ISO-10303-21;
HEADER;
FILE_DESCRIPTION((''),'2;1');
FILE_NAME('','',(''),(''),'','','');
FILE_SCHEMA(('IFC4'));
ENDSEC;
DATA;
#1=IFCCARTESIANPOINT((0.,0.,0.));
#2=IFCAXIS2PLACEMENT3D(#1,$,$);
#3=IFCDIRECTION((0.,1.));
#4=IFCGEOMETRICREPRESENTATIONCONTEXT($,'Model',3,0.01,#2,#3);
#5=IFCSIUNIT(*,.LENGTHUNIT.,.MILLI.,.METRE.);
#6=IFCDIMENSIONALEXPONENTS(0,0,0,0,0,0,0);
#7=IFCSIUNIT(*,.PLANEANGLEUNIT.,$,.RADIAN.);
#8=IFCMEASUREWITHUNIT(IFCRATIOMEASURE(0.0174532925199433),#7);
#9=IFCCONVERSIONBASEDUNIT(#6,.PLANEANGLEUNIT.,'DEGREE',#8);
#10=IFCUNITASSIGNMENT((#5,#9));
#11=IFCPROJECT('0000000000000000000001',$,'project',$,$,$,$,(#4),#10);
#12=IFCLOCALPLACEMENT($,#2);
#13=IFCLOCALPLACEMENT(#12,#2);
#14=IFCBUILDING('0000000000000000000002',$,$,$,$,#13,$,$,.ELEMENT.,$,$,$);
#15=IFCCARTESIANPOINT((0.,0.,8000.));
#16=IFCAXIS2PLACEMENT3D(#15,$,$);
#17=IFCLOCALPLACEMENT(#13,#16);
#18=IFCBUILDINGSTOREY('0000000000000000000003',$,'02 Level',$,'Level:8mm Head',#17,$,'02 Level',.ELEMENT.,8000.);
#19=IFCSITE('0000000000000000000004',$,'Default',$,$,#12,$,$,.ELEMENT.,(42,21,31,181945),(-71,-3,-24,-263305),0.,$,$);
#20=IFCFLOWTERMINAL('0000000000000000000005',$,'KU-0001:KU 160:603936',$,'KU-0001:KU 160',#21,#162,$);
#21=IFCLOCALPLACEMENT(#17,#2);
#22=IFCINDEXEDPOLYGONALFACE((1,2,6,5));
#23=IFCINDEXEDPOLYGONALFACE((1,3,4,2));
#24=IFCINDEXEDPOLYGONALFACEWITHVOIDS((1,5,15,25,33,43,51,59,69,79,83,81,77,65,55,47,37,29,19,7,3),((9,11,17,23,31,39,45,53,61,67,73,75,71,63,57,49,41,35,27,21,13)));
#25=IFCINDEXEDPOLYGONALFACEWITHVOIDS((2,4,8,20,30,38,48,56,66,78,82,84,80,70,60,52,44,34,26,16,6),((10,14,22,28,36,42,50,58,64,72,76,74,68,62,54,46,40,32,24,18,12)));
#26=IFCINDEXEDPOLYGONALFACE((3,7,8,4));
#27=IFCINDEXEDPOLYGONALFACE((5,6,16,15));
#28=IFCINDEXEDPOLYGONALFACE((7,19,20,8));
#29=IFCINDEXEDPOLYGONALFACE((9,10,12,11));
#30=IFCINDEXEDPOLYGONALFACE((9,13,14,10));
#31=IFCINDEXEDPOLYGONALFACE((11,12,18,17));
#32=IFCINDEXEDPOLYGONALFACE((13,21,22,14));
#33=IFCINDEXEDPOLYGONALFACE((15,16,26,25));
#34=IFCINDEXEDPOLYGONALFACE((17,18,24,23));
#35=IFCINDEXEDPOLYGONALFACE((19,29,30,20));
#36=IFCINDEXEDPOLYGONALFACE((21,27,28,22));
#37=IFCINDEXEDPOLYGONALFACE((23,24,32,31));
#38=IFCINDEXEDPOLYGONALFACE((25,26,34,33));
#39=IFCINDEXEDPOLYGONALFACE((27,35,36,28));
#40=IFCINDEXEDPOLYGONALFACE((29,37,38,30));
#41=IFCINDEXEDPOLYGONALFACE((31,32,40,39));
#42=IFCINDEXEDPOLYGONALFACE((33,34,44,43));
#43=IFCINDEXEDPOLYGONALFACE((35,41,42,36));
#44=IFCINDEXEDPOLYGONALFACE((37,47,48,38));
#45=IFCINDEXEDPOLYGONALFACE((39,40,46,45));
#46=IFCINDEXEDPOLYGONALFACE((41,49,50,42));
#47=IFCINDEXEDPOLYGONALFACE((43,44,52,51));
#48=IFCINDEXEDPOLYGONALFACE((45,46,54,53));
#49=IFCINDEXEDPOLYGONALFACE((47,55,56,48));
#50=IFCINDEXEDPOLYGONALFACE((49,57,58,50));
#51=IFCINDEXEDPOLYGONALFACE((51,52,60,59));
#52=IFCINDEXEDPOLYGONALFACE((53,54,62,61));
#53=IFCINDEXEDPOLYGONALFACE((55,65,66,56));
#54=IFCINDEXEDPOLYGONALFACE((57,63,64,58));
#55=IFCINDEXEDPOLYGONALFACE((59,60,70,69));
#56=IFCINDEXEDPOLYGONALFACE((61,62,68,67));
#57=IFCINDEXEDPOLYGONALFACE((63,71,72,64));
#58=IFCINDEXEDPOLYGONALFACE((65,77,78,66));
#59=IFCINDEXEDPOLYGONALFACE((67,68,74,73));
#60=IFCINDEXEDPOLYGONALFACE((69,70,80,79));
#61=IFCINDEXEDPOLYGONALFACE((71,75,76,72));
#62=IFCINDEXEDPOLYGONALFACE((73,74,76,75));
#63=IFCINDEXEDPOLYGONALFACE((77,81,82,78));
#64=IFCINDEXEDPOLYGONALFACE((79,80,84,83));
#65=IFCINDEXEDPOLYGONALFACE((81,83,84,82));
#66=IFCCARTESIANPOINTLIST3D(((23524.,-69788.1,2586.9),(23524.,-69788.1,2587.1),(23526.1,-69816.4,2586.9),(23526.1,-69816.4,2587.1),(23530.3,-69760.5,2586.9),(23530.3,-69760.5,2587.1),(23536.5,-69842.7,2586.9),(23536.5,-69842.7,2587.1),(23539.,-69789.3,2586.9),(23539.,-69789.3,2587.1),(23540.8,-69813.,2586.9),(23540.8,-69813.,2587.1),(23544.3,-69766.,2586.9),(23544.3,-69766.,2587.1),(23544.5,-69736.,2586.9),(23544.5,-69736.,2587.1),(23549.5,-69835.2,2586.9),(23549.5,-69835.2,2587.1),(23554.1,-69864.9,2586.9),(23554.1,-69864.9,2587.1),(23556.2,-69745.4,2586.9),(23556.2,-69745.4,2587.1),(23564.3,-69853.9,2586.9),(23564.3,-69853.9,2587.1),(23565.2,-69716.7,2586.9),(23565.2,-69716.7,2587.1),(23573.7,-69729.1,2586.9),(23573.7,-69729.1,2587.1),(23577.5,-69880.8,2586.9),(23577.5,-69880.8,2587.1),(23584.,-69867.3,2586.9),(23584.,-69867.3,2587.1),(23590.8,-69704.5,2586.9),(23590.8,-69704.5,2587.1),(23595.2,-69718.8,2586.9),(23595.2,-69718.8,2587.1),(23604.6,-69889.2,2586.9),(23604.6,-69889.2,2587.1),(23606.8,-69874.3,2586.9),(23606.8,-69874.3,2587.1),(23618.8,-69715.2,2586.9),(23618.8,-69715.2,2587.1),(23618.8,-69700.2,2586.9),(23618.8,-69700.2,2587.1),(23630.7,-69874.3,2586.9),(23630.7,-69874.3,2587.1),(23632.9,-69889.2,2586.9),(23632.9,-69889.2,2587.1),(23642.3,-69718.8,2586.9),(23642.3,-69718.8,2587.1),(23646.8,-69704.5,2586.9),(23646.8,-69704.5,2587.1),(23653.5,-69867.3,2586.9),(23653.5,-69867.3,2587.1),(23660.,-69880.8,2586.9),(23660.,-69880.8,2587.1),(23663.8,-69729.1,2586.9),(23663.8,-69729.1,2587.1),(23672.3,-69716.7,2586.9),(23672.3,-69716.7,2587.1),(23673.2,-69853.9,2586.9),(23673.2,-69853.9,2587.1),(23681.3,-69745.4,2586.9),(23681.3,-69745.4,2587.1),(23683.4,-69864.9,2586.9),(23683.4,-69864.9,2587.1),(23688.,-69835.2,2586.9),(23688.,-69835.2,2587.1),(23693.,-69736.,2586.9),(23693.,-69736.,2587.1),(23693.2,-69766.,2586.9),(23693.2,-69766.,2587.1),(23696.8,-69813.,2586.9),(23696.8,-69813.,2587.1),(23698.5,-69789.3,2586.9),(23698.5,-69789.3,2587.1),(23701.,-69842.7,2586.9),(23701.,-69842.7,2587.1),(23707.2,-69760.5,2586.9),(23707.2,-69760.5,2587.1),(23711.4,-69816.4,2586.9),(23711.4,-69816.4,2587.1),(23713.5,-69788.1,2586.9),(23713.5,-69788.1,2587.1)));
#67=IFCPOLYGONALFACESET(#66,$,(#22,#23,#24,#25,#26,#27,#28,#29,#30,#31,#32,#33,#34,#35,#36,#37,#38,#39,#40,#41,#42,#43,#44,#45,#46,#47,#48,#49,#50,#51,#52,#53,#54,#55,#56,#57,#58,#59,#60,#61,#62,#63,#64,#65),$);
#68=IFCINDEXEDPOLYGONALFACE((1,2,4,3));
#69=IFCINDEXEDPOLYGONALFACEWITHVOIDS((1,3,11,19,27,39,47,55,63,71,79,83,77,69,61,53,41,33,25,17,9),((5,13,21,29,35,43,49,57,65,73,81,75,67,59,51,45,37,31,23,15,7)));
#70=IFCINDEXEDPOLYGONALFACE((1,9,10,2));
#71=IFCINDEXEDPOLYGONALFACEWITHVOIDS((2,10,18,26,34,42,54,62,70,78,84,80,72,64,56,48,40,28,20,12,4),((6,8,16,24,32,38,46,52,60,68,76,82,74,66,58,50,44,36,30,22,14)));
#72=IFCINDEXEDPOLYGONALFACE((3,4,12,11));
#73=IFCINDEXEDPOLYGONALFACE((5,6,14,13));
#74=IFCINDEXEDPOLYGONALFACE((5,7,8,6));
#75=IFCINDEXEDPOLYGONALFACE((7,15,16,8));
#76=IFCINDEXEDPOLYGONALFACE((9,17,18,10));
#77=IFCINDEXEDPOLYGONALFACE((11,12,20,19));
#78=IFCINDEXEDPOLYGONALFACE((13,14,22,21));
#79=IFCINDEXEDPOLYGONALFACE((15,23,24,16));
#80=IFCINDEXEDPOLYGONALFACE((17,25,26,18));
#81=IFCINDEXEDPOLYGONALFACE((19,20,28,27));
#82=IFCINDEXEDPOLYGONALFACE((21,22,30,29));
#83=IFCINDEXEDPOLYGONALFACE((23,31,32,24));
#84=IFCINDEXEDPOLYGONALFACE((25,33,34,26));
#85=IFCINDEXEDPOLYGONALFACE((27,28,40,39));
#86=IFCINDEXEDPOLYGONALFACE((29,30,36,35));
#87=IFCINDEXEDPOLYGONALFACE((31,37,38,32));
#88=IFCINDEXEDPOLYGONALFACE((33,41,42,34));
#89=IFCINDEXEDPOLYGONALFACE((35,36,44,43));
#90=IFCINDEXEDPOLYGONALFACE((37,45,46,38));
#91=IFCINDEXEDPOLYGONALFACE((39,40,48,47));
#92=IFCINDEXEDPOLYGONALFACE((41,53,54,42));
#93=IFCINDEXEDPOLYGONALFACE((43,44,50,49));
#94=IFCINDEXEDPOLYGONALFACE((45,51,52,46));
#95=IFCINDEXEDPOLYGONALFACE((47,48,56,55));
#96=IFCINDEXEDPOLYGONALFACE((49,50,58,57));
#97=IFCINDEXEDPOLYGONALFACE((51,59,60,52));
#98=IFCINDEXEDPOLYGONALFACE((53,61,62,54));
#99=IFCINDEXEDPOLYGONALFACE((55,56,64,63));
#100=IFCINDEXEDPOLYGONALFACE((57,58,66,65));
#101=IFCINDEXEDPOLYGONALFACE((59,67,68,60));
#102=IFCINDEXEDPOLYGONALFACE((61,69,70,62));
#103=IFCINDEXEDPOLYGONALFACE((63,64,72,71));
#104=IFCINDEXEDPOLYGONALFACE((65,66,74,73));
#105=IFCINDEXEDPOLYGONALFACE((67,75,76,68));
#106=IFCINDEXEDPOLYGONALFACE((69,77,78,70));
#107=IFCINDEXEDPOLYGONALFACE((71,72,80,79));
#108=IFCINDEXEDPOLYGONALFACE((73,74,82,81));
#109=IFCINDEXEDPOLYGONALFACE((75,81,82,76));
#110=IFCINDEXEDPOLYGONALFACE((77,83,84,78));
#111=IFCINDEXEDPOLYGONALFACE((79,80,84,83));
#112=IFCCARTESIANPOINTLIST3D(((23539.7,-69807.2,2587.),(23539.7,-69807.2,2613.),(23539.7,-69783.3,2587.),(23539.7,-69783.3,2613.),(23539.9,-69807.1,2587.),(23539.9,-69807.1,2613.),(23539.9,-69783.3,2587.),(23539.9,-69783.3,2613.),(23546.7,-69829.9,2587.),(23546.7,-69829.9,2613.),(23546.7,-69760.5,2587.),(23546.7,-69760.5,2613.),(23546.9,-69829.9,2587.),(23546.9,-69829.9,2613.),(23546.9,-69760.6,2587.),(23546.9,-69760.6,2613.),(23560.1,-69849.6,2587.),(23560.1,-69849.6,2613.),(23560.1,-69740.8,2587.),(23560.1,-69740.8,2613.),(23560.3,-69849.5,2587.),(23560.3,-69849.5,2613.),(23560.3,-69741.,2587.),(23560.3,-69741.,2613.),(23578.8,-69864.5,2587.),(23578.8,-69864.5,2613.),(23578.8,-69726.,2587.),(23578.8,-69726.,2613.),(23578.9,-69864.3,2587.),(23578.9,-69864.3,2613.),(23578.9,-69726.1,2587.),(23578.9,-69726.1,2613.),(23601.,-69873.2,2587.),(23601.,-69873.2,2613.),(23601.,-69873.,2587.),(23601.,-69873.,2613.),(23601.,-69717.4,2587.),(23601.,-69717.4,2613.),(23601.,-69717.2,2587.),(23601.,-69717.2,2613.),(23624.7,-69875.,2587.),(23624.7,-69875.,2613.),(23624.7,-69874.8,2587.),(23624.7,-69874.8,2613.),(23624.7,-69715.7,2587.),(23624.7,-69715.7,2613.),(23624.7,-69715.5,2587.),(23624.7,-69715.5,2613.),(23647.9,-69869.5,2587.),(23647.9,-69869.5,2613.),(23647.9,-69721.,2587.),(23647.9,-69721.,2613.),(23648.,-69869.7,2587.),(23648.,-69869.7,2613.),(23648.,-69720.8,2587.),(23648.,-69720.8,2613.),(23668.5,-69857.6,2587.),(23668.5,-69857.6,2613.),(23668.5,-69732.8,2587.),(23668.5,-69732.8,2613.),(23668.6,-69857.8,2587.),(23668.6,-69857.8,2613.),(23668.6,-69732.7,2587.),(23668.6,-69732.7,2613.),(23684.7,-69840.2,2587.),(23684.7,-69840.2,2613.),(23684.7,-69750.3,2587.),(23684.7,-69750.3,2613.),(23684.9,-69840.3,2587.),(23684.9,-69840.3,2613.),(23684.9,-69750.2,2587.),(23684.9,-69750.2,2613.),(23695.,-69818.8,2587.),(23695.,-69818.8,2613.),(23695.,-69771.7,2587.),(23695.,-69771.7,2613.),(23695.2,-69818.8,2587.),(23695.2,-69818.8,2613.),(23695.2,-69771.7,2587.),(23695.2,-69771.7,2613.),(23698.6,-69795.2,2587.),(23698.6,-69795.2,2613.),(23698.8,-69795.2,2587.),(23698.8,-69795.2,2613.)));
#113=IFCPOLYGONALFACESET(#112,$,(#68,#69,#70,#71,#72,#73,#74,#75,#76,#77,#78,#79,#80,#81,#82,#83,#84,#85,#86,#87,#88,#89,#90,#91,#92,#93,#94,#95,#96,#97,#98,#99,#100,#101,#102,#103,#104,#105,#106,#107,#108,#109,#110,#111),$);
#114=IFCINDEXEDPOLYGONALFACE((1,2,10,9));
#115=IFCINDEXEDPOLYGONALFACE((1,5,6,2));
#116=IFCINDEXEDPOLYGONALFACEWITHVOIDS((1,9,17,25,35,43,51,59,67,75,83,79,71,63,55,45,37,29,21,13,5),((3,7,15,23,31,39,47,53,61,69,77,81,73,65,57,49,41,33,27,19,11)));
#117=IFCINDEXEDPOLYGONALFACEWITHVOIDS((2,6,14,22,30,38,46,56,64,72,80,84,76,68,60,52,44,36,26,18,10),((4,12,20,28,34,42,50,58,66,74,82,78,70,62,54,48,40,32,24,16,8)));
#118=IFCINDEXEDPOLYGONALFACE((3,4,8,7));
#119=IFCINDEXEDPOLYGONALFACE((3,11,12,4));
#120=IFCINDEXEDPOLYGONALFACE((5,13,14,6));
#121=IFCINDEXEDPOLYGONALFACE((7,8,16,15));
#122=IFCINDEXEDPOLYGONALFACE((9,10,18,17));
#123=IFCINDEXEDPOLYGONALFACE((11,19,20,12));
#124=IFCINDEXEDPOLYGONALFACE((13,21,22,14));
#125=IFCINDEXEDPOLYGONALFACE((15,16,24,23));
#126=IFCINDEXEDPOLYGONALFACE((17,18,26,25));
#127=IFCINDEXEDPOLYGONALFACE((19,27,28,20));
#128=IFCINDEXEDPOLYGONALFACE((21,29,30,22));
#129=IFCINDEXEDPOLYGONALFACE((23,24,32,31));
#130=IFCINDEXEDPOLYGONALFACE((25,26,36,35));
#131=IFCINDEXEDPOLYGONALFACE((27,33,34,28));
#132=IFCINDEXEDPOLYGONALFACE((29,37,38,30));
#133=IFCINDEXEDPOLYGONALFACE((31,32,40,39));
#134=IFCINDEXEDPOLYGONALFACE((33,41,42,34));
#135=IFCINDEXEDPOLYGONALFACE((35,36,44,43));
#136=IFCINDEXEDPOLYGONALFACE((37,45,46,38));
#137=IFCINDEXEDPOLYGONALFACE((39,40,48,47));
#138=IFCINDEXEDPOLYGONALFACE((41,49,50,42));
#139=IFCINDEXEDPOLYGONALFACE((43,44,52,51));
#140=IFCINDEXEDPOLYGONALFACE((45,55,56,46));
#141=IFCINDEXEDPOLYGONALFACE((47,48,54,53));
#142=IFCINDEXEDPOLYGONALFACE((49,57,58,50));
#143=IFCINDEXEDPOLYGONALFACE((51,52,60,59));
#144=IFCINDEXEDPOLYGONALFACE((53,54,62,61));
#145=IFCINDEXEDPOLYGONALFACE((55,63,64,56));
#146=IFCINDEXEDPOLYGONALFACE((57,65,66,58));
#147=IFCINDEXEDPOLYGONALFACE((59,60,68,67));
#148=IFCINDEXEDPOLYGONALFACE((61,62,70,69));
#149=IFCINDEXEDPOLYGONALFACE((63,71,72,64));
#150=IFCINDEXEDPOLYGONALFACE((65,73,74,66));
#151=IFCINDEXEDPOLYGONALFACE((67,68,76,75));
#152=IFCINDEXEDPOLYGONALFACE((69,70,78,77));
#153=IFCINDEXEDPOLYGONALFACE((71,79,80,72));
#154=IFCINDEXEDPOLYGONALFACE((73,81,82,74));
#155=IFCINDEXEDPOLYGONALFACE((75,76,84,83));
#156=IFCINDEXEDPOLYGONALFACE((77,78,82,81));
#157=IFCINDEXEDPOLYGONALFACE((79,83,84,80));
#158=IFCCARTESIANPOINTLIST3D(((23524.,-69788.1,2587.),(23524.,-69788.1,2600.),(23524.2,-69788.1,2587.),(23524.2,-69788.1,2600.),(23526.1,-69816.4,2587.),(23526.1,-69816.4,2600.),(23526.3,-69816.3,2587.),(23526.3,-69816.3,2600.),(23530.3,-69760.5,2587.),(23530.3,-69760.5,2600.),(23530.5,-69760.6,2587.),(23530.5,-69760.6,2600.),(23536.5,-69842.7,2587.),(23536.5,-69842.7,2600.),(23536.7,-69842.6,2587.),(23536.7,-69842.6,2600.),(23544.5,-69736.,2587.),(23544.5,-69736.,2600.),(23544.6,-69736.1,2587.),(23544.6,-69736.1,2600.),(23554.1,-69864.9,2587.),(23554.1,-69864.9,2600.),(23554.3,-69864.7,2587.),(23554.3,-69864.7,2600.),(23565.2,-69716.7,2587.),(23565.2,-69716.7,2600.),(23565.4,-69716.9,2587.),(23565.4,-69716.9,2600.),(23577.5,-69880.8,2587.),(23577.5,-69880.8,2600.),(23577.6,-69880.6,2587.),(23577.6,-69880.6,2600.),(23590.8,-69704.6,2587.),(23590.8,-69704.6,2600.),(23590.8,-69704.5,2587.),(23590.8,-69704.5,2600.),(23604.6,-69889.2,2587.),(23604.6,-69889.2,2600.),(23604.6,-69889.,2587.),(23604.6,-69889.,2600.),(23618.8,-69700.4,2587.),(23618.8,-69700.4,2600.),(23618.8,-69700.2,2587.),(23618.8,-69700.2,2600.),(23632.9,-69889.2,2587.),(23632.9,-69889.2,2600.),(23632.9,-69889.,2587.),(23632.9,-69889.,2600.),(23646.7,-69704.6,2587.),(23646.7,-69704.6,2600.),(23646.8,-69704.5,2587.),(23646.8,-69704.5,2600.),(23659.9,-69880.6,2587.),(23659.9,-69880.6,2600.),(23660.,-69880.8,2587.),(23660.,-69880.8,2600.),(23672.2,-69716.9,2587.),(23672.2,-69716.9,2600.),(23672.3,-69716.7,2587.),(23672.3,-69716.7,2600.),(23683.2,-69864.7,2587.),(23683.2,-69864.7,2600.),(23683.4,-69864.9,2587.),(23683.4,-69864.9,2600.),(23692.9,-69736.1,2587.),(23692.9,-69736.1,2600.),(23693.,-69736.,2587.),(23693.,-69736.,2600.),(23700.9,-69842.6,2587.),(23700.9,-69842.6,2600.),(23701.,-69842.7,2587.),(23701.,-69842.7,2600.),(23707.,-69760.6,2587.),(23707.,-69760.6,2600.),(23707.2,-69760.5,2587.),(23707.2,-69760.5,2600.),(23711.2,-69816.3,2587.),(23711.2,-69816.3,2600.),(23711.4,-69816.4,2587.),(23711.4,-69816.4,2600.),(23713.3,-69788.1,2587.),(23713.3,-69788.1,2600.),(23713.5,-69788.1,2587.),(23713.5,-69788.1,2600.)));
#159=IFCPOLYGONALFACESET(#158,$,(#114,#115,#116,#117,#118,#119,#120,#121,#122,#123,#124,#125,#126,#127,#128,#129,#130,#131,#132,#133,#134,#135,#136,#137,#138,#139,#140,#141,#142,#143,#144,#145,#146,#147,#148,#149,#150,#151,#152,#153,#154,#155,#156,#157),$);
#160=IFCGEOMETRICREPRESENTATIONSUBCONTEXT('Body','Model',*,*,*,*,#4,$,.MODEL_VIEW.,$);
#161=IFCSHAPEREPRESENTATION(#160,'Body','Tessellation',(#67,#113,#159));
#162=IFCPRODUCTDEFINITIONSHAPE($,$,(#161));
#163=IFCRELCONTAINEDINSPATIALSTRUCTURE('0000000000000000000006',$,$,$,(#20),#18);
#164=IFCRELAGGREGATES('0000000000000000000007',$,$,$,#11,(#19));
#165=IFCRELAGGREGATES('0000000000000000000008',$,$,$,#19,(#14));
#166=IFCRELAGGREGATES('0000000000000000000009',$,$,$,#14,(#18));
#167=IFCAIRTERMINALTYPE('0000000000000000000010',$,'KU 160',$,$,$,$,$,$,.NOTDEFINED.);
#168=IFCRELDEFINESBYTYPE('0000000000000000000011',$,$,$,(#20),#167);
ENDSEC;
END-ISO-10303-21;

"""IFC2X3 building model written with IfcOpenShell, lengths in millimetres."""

from ifc_helpers import new_model, entity, si_unit, converted_unit, direction, frame, frame_2d, origin, place, context, subcontext, project, spatial, hollow_circle, extrude, source, transform, mapped, type_object, type_shapes, element, save


model = new_model("IFC2X3")

# Units and contexts
model_context = context("Model", 3, precision=0.01, world=origin(), true_north=direction((0.0, 1.0)))
body_context = subcontext(model_context, "Body", "Model", "MODEL_VIEW")
ifc_project = project(units=[si_unit("LENGTHUNIT", "METRE", prefix="MILLI"), converted_unit("PLANEANGLEUNIT", "DEGREE", entity("IfcRatioMeasure", 0.0174532925199433), si_unit("PLANEANGLEUNIT", "RADIAN"), dimensions=[0, 0, 0, 0, 0, 0, 0])], contexts=[model_context])

# Site, building, storey
site_placement = place(None, origin())
site = spatial("IfcSite", under=ifc_project, at=site_placement, Name="Default", CompositionType="ELEMENT", RefLatitude=(42, 21, 31, 181945), RefLongitude=(-71, -3, -24, -263305), RefElevation=0.0)
building_placement = place(site_placement, origin())
building = spatial("IfcBuilding", under=site, at=building_placement, CompositionType="ELEMENT")
storey_placement = place(building_placement, frame((0.0, 0.0, 8000.0)))
storey = spatial("IfcBuildingStorey", under=building, at=storey_placement, Name="02 Level", ObjectType="Level:8mm Head", LongName="02 Level", CompositionType="ELEMENT", Elevation=8000.0)

# Flow terminal
air_terminal_type_1 = type_object("IfcAirTerminalType", Name="KU 160", PredefinedType="NOTDEFINED")
shared_shape_1 = source(origin(), body_context, "Body", "SweptSolid", [
    extrude(hollow_circle(Radius=95.0, WallThickness=15.0, at=frame_2d((0.0, 0.0), x_axis=(1.0, 0.0))), frame((12.9, 0.0, 0.0), z_axis=(1.0, 0.0, 0.0), x_axis=(0.0, 1.0, 0.0)), (0.0, 0.0, 1.0), 0.2),
    extrude(hollow_circle(Radius=80.0, WallThickness=0.2, at=frame_2d((0.0, 0.0), x_axis=(1.0, 0.0))), frame((-13.0, 0.0, 0.0), z_axis=(1.0, 0.0, 0.0), x_axis=(0.0, 0.0, 1.0)), (0.0, 0.0, 1.0), 26.0),
    extrude(hollow_circle(Radius=95.0, WallThickness=0.2, at=frame_2d((0.0, 0.0), x_axis=(1.0, 0.0))), frame((0.0, 0.0, 0.0), z_axis=(1.0, 0.0, 0.0), x_axis=(0.0, 1.0, 0.0)), (0.0, 0.0, 1.0), 13.0),
])
type_shapes(air_terminal_type_1, [shared_shape_1])
for number, where, z_axis, x_axis, name in (
    (1, (23618.8, -69795.2, 2600.0), (1.0, 0.0, 0.0), (0.0, 0.0, -1.0), "KU-0001:KU 160:603936"),
):
    element("IfcFlowTerminal", number, at=place(storey_placement, frame(where, z_axis=z_axis, x_axis=x_axis)), inside=storey, type_object=air_terminal_type_1, Name=name, ObjectType="KU-0001:KU 160", context=body_context, shape_type="MappedRepresentation", body=[
        mapped(shared_shape_1, transform((0.0, 0.0, 0.0), scale=1.0)),
    ])

save(model, "model.ifc")
